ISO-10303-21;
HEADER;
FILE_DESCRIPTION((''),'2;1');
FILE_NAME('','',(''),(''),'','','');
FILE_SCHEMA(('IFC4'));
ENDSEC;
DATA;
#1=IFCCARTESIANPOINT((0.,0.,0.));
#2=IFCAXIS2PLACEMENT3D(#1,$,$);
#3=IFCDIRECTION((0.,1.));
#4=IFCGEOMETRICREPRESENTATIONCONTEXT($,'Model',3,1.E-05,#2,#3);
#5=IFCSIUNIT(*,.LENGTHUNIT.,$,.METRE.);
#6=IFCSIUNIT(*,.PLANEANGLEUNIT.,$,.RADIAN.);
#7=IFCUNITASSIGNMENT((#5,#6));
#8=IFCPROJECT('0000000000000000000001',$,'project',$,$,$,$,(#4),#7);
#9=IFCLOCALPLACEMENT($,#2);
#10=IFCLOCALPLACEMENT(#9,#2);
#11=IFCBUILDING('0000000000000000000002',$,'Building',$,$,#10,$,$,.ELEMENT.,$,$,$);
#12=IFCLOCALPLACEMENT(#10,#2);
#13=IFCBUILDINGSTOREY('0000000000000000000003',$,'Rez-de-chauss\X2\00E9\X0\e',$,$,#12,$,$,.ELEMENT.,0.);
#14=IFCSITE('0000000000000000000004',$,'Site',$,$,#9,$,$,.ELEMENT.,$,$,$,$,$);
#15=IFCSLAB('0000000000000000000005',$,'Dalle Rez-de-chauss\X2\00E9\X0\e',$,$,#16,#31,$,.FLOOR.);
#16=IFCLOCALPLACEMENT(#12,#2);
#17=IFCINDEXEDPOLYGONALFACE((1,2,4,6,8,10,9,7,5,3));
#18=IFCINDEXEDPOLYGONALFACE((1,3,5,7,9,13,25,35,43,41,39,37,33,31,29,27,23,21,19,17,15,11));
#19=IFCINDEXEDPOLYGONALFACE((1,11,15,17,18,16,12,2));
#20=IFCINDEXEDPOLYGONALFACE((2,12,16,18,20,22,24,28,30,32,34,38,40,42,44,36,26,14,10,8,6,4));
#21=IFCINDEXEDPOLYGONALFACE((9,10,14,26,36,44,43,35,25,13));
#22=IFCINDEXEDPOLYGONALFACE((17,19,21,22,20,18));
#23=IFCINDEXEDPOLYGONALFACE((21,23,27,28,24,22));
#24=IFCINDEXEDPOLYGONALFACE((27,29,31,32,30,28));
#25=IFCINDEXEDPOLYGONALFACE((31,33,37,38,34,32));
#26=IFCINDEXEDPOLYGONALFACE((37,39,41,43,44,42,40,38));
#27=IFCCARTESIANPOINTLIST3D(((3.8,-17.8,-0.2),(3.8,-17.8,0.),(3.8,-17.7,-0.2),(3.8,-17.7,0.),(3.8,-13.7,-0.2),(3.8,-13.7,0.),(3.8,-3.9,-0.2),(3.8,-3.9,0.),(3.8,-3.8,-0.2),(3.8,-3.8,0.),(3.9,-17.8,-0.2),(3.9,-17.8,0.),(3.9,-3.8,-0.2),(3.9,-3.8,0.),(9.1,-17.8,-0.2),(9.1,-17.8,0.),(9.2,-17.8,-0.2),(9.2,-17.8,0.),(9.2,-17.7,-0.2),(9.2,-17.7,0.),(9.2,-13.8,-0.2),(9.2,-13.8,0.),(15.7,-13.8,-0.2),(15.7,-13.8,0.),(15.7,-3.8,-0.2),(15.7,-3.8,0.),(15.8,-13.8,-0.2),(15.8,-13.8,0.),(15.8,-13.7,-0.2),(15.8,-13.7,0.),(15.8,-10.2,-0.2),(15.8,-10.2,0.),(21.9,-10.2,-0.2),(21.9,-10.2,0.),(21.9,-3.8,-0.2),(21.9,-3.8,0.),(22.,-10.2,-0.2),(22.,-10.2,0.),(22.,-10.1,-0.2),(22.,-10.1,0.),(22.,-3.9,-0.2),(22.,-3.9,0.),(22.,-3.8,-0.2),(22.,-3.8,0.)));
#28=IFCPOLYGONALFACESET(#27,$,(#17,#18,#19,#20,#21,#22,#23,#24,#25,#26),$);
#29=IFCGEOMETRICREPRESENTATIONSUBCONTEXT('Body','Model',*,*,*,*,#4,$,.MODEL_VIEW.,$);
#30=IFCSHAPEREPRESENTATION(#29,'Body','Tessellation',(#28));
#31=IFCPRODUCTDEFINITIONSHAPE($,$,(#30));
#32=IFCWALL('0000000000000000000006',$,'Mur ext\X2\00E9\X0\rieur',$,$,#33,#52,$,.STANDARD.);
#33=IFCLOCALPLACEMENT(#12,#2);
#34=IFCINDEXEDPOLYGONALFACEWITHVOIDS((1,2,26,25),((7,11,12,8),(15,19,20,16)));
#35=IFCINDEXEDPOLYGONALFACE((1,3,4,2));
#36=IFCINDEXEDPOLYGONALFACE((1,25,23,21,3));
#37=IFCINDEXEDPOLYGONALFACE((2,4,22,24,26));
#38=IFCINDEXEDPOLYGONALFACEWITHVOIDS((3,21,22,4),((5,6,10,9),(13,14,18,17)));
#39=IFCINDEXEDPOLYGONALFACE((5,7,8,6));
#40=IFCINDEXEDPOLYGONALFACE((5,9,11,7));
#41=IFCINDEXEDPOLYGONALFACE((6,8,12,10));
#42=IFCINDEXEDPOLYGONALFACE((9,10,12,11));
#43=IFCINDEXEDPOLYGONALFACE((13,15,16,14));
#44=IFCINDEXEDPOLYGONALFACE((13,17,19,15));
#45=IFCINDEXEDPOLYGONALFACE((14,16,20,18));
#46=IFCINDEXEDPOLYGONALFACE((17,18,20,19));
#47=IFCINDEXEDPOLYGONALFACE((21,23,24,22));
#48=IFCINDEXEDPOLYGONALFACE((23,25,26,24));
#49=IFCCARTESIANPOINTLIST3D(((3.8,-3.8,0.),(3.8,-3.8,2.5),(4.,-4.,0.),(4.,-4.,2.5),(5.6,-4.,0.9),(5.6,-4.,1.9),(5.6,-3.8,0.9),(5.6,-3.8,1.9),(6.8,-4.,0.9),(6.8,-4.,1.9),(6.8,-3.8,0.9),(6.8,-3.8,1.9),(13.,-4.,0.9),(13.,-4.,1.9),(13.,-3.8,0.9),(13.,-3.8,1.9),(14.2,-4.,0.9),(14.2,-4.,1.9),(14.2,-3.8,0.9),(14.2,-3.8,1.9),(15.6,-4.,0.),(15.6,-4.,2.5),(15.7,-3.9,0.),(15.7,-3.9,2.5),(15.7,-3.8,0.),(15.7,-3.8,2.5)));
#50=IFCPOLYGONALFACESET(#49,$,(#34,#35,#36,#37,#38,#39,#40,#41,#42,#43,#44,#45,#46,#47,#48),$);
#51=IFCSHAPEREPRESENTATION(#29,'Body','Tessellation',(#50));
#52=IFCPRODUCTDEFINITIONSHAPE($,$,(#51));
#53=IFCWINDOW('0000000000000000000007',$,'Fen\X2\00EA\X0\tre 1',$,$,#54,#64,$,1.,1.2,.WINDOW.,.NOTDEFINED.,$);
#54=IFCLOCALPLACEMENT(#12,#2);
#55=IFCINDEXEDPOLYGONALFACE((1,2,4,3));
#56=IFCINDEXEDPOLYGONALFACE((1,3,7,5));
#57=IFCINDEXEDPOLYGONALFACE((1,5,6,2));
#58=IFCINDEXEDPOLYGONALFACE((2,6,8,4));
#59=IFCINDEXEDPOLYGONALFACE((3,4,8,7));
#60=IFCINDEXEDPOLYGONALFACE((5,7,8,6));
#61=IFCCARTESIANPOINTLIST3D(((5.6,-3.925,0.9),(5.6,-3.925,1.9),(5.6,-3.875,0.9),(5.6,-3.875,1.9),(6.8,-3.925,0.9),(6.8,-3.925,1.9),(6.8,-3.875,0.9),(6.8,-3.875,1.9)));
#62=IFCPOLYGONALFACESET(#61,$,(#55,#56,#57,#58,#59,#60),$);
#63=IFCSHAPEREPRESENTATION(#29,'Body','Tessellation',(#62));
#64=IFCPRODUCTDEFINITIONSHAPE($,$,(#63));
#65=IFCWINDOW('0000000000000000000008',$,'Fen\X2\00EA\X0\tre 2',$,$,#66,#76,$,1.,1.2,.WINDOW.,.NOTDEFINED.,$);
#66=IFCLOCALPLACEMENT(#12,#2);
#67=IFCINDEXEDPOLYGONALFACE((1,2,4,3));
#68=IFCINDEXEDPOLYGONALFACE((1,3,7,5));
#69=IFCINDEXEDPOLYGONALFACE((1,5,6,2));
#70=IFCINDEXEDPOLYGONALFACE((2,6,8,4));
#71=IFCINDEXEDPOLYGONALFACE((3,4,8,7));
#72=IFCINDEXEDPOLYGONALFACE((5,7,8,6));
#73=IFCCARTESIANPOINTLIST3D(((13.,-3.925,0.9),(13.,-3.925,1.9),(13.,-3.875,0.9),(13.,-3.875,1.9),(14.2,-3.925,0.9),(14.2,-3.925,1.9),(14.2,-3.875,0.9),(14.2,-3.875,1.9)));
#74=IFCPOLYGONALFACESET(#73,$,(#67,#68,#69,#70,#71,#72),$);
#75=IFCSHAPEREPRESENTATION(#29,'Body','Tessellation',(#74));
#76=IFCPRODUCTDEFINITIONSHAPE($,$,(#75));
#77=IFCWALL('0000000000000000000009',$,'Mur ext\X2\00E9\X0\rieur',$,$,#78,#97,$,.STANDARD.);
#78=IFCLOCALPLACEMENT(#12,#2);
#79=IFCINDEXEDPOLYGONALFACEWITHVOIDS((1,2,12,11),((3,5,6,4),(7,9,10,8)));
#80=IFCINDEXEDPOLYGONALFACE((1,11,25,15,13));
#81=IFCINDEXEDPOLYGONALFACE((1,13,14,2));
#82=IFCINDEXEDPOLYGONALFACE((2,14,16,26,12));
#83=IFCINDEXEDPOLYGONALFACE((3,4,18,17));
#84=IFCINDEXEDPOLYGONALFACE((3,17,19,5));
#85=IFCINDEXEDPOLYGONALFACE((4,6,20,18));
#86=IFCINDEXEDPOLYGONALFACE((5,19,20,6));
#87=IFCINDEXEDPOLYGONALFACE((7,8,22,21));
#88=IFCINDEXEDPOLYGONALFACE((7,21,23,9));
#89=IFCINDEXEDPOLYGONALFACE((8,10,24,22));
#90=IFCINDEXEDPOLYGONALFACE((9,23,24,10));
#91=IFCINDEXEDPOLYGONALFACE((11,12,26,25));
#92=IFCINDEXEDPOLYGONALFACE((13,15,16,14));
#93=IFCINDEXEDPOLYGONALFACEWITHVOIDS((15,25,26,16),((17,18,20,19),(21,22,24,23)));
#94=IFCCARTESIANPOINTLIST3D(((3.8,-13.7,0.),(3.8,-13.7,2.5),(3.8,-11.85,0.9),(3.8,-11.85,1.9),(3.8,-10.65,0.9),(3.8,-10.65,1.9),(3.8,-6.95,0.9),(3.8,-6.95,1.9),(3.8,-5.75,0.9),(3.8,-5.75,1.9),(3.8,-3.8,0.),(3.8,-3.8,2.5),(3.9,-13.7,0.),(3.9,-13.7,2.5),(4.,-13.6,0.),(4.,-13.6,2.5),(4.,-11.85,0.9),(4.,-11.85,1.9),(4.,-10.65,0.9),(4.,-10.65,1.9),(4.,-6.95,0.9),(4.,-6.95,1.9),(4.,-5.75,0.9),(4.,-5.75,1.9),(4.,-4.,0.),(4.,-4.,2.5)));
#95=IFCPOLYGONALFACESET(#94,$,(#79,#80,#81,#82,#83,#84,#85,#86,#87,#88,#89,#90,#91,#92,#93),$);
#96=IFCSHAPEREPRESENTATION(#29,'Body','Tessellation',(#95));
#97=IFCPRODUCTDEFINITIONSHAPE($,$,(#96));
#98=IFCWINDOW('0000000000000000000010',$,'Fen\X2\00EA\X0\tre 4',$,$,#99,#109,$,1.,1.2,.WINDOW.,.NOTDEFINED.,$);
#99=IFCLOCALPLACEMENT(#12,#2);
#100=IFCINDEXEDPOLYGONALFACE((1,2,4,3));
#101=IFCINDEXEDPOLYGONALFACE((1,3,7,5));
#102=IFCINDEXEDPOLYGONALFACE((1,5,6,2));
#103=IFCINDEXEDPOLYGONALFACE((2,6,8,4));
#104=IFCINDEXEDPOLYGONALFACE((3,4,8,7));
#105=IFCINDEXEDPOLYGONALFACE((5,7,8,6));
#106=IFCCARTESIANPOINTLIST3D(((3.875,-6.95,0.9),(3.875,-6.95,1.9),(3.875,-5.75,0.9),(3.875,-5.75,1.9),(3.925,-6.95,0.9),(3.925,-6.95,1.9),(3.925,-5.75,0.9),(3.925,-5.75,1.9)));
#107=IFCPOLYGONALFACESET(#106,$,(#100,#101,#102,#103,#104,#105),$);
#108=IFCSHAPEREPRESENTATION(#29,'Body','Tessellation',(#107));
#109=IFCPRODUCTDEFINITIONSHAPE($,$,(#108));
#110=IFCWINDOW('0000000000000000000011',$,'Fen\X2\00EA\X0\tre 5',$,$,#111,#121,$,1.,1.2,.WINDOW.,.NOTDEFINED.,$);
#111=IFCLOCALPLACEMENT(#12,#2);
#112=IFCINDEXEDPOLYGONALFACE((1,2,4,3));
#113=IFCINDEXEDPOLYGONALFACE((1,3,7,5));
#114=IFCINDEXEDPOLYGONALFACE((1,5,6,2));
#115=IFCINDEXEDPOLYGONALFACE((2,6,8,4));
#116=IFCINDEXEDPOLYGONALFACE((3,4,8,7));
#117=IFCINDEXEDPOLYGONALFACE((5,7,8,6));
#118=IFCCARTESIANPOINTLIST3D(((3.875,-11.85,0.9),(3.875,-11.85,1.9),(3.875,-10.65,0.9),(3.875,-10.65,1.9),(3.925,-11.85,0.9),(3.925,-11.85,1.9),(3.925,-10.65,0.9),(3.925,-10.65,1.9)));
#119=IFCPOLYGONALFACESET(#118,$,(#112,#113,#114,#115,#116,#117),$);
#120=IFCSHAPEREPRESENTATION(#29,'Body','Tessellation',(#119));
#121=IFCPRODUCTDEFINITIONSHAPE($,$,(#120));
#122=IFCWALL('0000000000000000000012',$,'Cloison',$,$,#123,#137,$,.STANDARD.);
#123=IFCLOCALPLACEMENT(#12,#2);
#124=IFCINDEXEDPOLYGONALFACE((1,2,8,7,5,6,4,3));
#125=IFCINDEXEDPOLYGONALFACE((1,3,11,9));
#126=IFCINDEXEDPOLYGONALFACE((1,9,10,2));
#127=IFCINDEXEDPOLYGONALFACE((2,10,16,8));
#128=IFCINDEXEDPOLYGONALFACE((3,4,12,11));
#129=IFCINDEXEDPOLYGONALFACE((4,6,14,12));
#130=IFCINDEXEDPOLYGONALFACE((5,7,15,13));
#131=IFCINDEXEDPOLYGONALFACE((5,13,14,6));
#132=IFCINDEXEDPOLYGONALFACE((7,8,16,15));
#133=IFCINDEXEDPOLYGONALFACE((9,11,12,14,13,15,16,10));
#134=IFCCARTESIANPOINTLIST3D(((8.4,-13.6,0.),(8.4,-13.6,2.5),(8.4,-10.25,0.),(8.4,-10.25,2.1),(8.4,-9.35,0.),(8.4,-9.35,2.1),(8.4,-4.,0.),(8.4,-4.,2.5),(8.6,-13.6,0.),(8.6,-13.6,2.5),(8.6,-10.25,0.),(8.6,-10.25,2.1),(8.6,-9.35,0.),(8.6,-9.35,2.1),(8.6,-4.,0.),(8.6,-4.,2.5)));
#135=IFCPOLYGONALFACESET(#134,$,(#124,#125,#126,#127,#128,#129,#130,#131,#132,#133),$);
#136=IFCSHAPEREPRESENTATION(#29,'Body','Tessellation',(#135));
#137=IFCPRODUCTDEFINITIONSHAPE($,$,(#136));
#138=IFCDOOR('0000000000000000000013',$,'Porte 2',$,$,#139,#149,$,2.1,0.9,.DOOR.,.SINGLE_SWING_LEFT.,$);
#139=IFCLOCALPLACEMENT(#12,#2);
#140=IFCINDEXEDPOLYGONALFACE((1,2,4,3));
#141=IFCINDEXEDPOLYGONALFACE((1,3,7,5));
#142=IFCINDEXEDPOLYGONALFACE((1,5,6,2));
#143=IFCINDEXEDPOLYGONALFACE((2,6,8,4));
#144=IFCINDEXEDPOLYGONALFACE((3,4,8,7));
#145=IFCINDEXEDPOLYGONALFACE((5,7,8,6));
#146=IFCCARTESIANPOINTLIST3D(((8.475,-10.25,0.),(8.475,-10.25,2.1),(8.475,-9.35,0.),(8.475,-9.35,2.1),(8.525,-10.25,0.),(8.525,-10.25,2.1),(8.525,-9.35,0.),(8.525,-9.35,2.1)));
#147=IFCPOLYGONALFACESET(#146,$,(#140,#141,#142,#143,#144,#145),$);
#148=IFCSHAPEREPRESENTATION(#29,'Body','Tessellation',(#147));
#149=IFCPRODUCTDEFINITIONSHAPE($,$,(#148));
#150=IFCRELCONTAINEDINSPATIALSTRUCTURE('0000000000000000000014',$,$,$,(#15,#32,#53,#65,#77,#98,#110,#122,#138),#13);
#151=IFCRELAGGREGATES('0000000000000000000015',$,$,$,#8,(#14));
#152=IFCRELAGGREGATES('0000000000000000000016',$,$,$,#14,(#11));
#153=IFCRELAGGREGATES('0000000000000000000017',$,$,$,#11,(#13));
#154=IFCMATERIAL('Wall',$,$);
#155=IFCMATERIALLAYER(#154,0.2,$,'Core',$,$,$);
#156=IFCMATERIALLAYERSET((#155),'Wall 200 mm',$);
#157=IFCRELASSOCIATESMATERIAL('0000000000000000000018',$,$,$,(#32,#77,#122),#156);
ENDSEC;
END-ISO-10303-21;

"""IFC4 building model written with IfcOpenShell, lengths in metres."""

from ifc_helpers import new_model, si_unit, direction, frame, origin, origin_2d, place, context, subcontext, project, spatial, polyline, rectangle, outline, extrude, material, layer, layer_set, layer_usage, element, fill, save


model = new_model("IFC4")

# Units and contexts
model_context = context("Model", 3, precision=1e-05, world=origin(), true_north=direction((0.0, 1.0)))
body_context = subcontext(model_context, "Body", "Model", "MODEL_VIEW")
ifc_project = project(units=[si_unit("LENGTHUNIT", "METRE"), si_unit("PLANEANGLEUNIT", "RADIAN")], contexts=[model_context])

# Site, building, storey
site_placement = place(None, origin())
site = spatial("IfcSite", under=ifc_project, at=site_placement, Name="Site", CompositionType="ELEMENT")
building_placement = place(site_placement, origin())
building = spatial("IfcBuilding", under=site, at=building_placement, Name="Building", CompositionType="ELEMENT")
storey_placement = place(building_placement, origin())
storey = spatial("IfcBuildingStorey", under=building, at=storey_placement, Name="Rez-de-chaussée", CompositionType="ELEMENT", Elevation=0.0)

# Slab
slab_placement = place(storey_placement, origin())
element("IfcSlab", 1, at=slab_placement, inside=storey, Name="Dalle Rez-de-chaussée", PredefinedType="FLOOR", context=body_context, shape_type="SweptSolid", body=[
    extrude(outline(polyline([(3.8, -3.8), (3.8, -3.9), (3.8, -13.7), (3.8, -17.7), (3.8, -17.8), (3.9, -17.8), (9.1, -17.8), (9.2, -17.8), (9.2, -17.7), (9.2, -13.8), (15.7, -13.8), (15.8, -13.8), (15.8, -13.7), (15.8, -10.2), (21.9, -10.2), (22.0, -10.2), (22.0, -10.1), (22.0, -3.9), (22.0, -3.8), (21.9, -3.8), (15.7, -3.8), (3.9, -3.8), (3.8, -3.8)])), frame((0.0, 0.0, -0.2)), (0.0, 0.0, 1.0), 0.2),
])

# Walls, openings, windows
ifc_material = material(Name="Wall")
ifc_layer = layer(ifc_material, 0.2, Name="Core")
ifc_layer_set = layer_set([ifc_layer], Name="Wall 200 mm")
ifc_layer_usage = layer_usage(ifc_layer_set, "AXIS2", "POSITIVE", -0.1)
wall_1_placement = place(storey_placement, frame((3.9, -3.9, 0.0)))
wall_1 = element("IfcWall", 2, at=wall_1_placement, inside=storey, material=ifc_layer_usage, Name="Mur extérieur", PredefinedType="STANDARD", context=body_context, shape_type="SweptSolid", body=[
    extrude(outline(polyline([(0.0, 0.0), (0.1, -0.1), (11.7, -0.1), (11.8, 0.0), (11.8, 0.1), (-0.1, 0.1), (0.0, 0.0)])), origin(), (0.0, 0.0, 1.0), 2.5),
])
opening_1_placement = place(wall_1_placement, frame((2.3, 0.0, 0.9)))
opening_1 = element("IfcOpeningElement", 3, at=opening_1_placement, cuts=wall_1, PredefinedType="OPENING", context=body_context, shape_type="SweptSolid", body=[
    extrude(rectangle(XDim=1.2, YDim=0.4, at=origin_2d()), origin(), (0.0, 0.0, 1.0), 1.0),
])
opening_2_placement = place(wall_1_placement, frame((9.7, 0.0, 0.9)))
opening_2 = element("IfcOpeningElement", 4, at=opening_2_placement, cuts=wall_1, PredefinedType="OPENING", context=body_context, shape_type="SweptSolid", body=[
    extrude(rectangle(XDim=1.2, YDim=0.4, at=origin_2d()), origin(), (0.0, 0.0, 1.0), 1.0),
])
window_1_placement = place(opening_1_placement, origin())
window_1 = element("IfcWindow", 5, at=window_1_placement, inside=storey, Name="Fenêtre 1", OverallHeight=1.0, OverallWidth=1.2, PartitioningType="NOTDEFINED", PredefinedType="WINDOW", context=body_context, shape_type="SweptSolid", body=[
    extrude(rectangle(XDim=1.2, YDim=0.05, at=origin_2d()), origin(), (0.0, 0.0, 1.0), 1.0),
])
fill(opening_1, window_1)
window_2_placement = place(opening_2_placement, origin())
window_2 = element("IfcWindow", 6, at=window_2_placement, inside=storey, Name="Fenêtre 2", OverallHeight=1.0, OverallWidth=1.2, PartitioningType="NOTDEFINED", PredefinedType="WINDOW", context=body_context, shape_type="SweptSolid", body=[
    extrude(rectangle(XDim=1.2, YDim=0.05, at=origin_2d()), origin(), (0.0, 0.0, 1.0), 1.0),
])
fill(opening_2, window_2)
wall_2_placement = place(storey_placement, frame((3.9, -13.7, 0.0), z_axis=(0.0, 0.0, 1.0), x_axis=(0.0, 1.0, 0.0)))
wall_2 = element("IfcWall", 7, at=wall_2_placement, inside=storey, material=ifc_layer_usage, Name="Mur extérieur", PredefinedType="STANDARD", context=body_context, shape_type="SweptSolid", body=[
    extrude(outline(polyline([(0.0, 0.0), (0.1, -0.1), (9.7, -0.1), (9.8, 0.0), (9.9, 0.1), (0.0, 0.1), (0.0, 0.0)])), origin(), (0.0, 0.0, 1.0), 2.5),
])
opening_3_placement = place(wall_2_placement, frame((7.35, 0.0, 0.9)))
opening_3 = element("IfcOpeningElement", 8, at=opening_3_placement, cuts=wall_2, PredefinedType="OPENING", context=body_context, shape_type="SweptSolid", body=[
    extrude(rectangle(XDim=1.2, YDim=0.4, at=origin_2d()), origin(), (0.0, 0.0, 1.0), 1.0),
])
opening_4_placement = place(wall_2_placement, frame((2.45, 0.0, 0.9)))
opening_4 = element("IfcOpeningElement", 9, at=opening_4_placement, cuts=wall_2, PredefinedType="OPENING", context=body_context, shape_type="SweptSolid", body=[
    extrude(rectangle(XDim=1.2, YDim=0.4, at=origin_2d()), origin(), (0.0, 0.0, 1.0), 1.0),
])
window_3_placement = place(opening_3_placement, origin())
window_3 = element("IfcWindow", 10, at=window_3_placement, inside=storey, Name="Fenêtre 4", OverallHeight=1.0, OverallWidth=1.2, PartitioningType="NOTDEFINED", PredefinedType="WINDOW", context=body_context, shape_type="SweptSolid", body=[
    extrude(rectangle(XDim=1.2, YDim=0.05, at=origin_2d()), origin(), (0.0, 0.0, 1.0), 1.0),
])
fill(opening_3, window_3)
window_4_placement = place(opening_4_placement, origin())
window_4 = element("IfcWindow", 11, at=window_4_placement, inside=storey, Name="Fenêtre 5", OverallHeight=1.0, OverallWidth=1.2, PartitioningType="NOTDEFINED", PredefinedType="WINDOW", context=body_context, shape_type="SweptSolid", body=[
    extrude(rectangle(XDim=1.2, YDim=0.05, at=origin_2d()), origin(), (0.0, 0.0, 1.0), 1.0),
])
fill(opening_4, window_4)

# Wall, opening, door
wall_3_placement = place(storey_placement, frame((8.5, -3.9, 0.0), z_axis=(0.0, 0.0, 1.0), x_axis=(0.0, -1.0, 0.0)))
wall_3 = element("IfcWall", 12, at=wall_3_placement, inside=storey, material=ifc_layer_usage, Name="Cloison", PredefinedType="STANDARD", context=body_context, shape_type="SweptSolid", body=[
    extrude(outline(polyline([(0.1, 0.0), (0.1, -0.1), (9.7, -0.1), (9.7, 0.0), (9.7, 0.1), (0.1, 0.1), (0.1, 0.0)])), origin(), (0.0, 0.0, 1.0), 2.5),
])
opening_5_placement = place(wall_3_placement, frame((5.9, 0.0, 0.0)))
opening_5 = element("IfcOpeningElement", 13, at=opening_5_placement, cuts=wall_3, PredefinedType="OPENING", context=body_context, shape_type="SweptSolid", body=[
    extrude(rectangle(XDim=0.9, YDim=0.4, at=origin_2d()), origin(), (0.0, 0.0, 1.0), 2.1),
])
door_placement = place(opening_5_placement, origin())
door = element("IfcDoor", 14, at=door_placement, inside=storey, Name="Porte 2", OperationType="SINGLE_SWING_LEFT", OverallHeight=2.1, OverallWidth=0.9, PredefinedType="DOOR", context=body_context, shape_type="SweptSolid", body=[
    extrude(rectangle(XDim=0.9, YDim=0.05, at=origin_2d()), origin(), (0.0, 0.0, 1.0), 2.1),
])
fill(opening_5, door)

save(model, "model.ifc")
